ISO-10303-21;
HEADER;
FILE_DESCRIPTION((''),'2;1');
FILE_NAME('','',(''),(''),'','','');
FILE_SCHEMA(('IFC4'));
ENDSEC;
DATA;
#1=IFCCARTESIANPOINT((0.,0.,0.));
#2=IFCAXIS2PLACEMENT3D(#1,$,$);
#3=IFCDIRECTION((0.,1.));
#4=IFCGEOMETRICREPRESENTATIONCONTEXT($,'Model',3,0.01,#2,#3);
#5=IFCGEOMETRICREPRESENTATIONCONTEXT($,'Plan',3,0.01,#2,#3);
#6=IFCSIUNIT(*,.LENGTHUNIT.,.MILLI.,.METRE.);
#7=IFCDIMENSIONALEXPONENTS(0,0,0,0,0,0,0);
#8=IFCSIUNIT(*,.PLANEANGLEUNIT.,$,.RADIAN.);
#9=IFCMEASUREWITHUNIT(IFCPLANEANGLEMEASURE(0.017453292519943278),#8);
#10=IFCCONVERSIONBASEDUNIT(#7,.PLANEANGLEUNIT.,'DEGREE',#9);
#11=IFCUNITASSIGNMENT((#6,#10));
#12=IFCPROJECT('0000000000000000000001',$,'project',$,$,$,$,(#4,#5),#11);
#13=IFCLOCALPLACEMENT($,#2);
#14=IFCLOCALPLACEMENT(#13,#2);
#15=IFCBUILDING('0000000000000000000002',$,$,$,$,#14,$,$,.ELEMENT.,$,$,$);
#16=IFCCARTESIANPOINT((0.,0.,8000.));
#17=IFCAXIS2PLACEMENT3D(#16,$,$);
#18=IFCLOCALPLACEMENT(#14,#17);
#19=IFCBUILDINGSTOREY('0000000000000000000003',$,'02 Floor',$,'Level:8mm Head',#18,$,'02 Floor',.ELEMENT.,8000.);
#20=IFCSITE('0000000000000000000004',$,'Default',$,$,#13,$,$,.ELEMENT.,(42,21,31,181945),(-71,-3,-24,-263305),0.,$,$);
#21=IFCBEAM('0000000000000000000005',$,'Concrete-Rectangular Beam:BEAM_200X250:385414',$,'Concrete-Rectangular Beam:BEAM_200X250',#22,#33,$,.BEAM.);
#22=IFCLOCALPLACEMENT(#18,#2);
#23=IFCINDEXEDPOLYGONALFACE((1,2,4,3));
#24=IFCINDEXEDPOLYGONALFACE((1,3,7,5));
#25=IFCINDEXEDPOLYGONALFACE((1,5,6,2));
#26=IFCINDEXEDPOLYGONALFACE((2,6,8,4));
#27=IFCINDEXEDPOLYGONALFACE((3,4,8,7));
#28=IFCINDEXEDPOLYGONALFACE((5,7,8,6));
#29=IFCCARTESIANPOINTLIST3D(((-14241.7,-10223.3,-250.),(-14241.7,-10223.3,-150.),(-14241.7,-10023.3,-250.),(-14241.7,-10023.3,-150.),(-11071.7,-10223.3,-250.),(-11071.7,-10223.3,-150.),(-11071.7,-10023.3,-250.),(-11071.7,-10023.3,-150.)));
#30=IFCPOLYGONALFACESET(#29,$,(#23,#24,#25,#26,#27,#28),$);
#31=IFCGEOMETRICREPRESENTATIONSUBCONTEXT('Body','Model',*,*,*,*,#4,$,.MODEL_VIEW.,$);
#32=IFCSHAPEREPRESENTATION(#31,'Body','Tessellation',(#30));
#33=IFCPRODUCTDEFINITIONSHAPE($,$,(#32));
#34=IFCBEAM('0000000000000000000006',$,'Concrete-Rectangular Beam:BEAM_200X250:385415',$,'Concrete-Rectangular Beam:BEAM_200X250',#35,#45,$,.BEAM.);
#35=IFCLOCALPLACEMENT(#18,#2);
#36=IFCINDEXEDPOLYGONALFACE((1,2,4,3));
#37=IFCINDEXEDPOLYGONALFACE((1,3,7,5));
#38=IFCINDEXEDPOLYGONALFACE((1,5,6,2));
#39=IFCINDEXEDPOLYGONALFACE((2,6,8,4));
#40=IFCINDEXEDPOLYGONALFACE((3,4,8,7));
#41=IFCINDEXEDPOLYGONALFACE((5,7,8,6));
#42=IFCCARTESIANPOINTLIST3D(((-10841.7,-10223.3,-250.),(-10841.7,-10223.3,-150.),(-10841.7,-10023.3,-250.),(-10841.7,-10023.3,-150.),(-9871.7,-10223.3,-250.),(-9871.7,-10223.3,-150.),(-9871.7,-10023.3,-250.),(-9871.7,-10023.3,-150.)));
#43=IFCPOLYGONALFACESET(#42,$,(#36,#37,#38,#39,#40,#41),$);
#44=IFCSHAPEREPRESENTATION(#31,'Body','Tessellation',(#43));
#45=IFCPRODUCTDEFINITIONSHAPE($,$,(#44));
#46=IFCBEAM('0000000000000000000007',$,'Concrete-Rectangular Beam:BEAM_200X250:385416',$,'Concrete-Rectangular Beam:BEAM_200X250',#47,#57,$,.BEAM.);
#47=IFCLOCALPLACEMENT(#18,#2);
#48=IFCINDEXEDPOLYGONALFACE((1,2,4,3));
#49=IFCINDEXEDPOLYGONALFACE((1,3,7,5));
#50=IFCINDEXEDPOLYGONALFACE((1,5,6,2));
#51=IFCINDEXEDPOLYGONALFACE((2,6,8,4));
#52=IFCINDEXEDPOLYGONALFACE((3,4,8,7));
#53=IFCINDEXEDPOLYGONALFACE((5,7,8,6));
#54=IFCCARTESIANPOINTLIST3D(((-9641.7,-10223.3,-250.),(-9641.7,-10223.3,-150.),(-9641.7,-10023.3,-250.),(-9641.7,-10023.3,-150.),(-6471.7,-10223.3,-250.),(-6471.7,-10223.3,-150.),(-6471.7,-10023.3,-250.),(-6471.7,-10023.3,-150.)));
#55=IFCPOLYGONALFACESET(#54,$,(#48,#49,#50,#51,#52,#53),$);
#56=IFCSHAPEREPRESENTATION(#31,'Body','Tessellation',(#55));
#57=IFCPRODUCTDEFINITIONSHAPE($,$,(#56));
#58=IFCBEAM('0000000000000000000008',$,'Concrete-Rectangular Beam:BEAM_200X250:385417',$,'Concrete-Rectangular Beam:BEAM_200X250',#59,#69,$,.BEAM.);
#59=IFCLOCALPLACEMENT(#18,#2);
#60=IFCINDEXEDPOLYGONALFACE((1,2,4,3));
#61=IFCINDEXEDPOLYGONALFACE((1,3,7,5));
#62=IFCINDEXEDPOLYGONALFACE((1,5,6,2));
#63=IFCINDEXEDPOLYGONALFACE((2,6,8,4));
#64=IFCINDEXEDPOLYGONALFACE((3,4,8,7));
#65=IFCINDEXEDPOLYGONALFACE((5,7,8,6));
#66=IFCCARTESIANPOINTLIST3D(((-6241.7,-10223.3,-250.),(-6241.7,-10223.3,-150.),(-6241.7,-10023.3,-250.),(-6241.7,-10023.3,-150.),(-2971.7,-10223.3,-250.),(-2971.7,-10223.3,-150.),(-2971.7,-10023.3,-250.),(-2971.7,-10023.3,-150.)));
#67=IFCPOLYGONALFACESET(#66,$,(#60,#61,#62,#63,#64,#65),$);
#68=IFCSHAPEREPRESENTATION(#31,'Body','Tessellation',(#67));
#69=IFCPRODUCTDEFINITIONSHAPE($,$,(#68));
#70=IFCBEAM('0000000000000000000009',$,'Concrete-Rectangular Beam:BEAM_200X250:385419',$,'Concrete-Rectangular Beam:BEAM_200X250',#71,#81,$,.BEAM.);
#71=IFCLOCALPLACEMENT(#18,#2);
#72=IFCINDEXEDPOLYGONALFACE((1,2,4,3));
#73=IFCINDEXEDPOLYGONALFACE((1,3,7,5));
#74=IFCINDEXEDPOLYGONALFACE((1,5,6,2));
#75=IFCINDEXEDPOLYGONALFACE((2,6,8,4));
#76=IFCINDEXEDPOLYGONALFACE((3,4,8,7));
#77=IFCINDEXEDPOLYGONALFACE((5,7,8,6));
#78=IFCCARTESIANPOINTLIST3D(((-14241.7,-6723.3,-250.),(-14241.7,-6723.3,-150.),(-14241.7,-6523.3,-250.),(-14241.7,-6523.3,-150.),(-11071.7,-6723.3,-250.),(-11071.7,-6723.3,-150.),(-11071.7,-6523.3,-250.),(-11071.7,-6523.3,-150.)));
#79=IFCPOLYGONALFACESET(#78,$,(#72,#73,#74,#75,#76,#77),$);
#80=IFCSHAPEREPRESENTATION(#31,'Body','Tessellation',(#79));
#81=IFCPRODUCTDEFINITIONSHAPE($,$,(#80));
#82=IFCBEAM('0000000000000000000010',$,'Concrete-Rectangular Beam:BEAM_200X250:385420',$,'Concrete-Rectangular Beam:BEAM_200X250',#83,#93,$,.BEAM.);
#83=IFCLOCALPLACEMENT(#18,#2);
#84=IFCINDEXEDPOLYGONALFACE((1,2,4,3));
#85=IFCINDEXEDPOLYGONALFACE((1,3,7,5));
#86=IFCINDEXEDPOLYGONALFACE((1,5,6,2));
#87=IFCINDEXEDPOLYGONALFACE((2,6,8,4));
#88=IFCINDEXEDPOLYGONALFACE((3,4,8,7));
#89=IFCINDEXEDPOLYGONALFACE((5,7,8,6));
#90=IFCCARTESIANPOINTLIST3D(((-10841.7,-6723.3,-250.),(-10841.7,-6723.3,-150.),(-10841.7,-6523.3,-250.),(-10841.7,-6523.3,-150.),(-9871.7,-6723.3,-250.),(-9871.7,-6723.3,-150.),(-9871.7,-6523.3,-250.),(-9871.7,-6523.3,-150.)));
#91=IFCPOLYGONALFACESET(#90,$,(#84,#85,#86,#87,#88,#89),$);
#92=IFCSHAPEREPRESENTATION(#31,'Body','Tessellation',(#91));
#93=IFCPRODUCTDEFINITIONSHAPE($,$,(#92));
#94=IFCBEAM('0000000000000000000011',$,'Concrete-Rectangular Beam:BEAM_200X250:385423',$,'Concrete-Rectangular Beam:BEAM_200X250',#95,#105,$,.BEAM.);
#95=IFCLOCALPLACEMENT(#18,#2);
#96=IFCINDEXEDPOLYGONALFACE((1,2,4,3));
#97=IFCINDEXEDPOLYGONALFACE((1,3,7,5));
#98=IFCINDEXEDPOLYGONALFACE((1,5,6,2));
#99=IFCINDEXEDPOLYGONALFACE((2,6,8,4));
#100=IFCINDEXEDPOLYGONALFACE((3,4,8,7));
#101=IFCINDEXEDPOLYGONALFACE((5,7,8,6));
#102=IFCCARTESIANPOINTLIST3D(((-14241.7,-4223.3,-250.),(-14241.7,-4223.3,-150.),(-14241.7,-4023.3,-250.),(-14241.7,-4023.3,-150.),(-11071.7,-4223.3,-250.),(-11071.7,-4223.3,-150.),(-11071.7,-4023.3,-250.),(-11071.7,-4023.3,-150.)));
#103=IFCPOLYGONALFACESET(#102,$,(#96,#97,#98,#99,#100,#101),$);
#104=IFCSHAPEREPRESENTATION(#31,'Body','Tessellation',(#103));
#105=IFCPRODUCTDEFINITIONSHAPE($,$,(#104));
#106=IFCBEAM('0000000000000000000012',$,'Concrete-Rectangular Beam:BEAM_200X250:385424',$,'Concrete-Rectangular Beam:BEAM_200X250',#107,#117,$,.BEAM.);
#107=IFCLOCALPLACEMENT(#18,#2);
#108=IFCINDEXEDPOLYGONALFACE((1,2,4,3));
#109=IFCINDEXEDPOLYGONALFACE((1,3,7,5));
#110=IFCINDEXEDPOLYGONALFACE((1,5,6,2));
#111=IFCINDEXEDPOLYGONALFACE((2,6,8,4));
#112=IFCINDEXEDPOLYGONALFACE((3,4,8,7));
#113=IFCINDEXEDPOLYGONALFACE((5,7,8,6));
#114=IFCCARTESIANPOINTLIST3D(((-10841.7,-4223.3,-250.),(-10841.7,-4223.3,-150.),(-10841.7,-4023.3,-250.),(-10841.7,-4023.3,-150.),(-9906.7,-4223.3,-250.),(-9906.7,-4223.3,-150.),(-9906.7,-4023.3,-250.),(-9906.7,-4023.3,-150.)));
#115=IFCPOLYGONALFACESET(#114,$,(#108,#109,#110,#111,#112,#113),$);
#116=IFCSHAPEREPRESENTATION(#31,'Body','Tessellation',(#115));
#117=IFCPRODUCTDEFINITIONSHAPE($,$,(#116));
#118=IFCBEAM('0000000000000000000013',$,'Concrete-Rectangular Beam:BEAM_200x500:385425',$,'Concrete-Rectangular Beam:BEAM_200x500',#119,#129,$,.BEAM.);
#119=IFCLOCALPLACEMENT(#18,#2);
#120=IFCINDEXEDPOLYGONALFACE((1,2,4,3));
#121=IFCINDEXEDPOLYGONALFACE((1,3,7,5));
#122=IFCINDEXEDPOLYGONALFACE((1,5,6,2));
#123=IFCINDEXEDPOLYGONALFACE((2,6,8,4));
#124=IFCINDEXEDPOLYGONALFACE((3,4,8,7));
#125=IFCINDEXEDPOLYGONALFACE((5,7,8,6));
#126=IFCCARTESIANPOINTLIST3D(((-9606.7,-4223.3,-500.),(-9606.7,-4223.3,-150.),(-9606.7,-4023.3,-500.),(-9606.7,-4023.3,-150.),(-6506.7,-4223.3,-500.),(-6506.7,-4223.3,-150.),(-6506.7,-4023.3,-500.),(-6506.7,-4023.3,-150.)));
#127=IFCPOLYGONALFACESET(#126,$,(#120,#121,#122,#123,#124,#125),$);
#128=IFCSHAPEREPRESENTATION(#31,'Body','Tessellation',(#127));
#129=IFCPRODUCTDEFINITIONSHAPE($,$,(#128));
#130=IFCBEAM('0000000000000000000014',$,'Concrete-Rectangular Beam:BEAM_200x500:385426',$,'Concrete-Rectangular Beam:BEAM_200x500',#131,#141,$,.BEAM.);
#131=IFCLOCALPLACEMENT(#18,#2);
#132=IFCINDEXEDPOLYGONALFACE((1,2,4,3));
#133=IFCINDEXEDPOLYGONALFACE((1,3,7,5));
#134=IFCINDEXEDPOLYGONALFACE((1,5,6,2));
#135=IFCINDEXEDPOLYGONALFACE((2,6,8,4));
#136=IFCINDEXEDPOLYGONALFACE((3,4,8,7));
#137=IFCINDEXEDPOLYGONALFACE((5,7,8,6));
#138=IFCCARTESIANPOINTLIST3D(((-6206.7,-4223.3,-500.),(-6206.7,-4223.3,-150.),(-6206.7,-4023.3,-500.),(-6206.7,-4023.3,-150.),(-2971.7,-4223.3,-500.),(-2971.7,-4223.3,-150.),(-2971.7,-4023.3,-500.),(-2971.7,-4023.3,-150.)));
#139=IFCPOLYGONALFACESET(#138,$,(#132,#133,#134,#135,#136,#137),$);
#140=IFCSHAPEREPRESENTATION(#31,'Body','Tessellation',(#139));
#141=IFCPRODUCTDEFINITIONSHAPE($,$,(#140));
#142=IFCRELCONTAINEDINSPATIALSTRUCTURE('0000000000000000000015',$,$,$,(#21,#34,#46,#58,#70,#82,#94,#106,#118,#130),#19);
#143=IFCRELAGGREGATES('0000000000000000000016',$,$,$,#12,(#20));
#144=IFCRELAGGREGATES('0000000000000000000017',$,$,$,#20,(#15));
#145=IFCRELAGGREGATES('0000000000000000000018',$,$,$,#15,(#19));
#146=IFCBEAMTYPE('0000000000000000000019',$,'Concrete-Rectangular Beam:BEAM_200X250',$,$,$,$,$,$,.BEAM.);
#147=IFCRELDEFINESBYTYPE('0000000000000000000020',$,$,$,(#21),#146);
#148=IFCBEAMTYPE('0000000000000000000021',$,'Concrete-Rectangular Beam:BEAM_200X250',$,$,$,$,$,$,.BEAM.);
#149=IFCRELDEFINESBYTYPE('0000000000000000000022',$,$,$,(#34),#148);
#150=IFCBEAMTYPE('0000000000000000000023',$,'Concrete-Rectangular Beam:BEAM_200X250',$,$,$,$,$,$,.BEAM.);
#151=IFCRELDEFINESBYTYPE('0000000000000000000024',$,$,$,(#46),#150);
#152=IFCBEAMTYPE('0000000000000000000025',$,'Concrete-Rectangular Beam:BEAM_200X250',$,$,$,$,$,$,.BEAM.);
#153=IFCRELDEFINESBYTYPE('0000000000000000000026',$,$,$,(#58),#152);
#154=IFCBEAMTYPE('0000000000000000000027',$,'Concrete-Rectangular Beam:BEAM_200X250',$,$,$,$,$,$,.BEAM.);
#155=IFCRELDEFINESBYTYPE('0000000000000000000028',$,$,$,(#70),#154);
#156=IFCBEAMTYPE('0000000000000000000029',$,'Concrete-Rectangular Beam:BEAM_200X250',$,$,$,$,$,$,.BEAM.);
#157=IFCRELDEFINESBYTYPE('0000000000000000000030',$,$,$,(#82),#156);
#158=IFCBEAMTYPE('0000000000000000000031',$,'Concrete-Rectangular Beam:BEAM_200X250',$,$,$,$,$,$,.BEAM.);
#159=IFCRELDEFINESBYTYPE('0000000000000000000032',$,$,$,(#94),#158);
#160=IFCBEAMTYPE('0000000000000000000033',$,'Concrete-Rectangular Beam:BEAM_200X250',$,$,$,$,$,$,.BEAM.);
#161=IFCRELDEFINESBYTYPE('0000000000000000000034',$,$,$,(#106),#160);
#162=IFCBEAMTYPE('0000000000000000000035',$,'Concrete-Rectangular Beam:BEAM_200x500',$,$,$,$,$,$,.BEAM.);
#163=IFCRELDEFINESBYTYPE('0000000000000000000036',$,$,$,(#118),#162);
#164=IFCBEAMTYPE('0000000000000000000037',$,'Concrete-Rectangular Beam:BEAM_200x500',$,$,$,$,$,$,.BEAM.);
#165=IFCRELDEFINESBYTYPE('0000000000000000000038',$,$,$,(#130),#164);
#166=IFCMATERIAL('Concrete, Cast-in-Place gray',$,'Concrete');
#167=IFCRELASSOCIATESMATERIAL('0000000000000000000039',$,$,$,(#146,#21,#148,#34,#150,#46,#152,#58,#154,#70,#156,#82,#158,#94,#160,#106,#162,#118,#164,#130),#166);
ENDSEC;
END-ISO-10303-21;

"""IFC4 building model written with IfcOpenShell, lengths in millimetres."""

from ifc_helpers import new_model, entity, si_unit, converted_unit, direction, frame, origin, place, context, subcontext, project, spatial, indexed_curve, outline, extrude, source, transform, mapped, material, type_object, type_shapes, element, save


model = new_model("IFC4")

# Units and contexts
model_context = context("Model", 3, precision=0.01, world=origin(), true_north=direction((0.0, 1.0)))
plan_context = context("Plan", 3, precision=0.01, world=origin(), true_north=direction((0.0, 1.0)))
body_context = subcontext(model_context, "Body", "Model", "MODEL_VIEW")
ifc_project = project(units=[si_unit("LENGTHUNIT", "METRE", prefix="MILLI"), converted_unit("PLANEANGLEUNIT", "DEGREE", entity("IfcPlaneAngleMeasure", 0.017453292519943278), si_unit("PLANEANGLEUNIT", "RADIAN"), dimensions=[0, 0, 0, 0, 0, 0, 0])], contexts=[model_context, plan_context])

# Site, building, storey
site_placement = place(None, origin())
site = spatial("IfcSite", under=ifc_project, at=site_placement, Name="Default", CompositionType="ELEMENT", RefLatitude=(42, 21, 31, 181945), RefLongitude=(-71, -3, -24, -263305), RefElevation=0.0)
building_placement = place(site_placement, origin())
building = spatial("IfcBuilding", under=site, at=building_placement, CompositionType="ELEMENT")
storey_placement = place(building_placement, frame((0.0, 0.0, 8000.0)))
storey = spatial("IfcBuildingStorey", under=building, at=storey_placement, Name="02 Floor", ObjectType="Level:8mm Head", LongName="02 Floor", CompositionType="ELEMENT", Elevation=8000.0)

# Beams
ifc_material_1 = material(Name="Concrete, Cast-in-Place gray", Category="Concrete")
beam_type_1 = type_object("IfcBeamType", Name="Concrete-Rectangular Beam:BEAM_200X250", PredefinedType="BEAM", material=ifc_material_1)
shared_shape_1 = source(origin(), body_context, "Body", "SweptSolid", [
    extrude(outline(indexed_curve([(-50.0, -100.0), (50.0, -100.0), (50.0, 100.0), (-50.0, 100.0), (-50.0, -100.0)], self_intersect=False)), frame((-14241.7, -10123.3, 7800.0), z_axis=(1.0, 0.0, 0.0), x_axis=(0.0, 0.0, -1.0)), (0.0, 0.0, 1.0), 3170.0),
])
type_shapes(beam_type_1, [shared_shape_1])
beam_1_placement = place(storey_placement, frame((0.0, 0.0, -8000.0)))
element("IfcBeam", 1, at=beam_1_placement, inside=storey, type_object=beam_type_1, material=ifc_material_1, Name="Concrete-Rectangular Beam:BEAM_200X250:385414", ObjectType="Concrete-Rectangular Beam:BEAM_200X250", PredefinedType="BEAM", context=body_context, shape_type="MappedRepresentation", body=[
    mapped(shared_shape_1, transform((0.0, 0.0, 0.0), scale=1.0)),
])
beam_type_2 = type_object("IfcBeamType", Name="Concrete-Rectangular Beam:BEAM_200X250", PredefinedType="BEAM", material=ifc_material_1)
shared_shape_2 = source(origin(), body_context, "Body", "SweptSolid", [
    extrude(outline(indexed_curve([(-50.0, -100.0), (50.0, -100.0), (50.0, 100.0), (-50.0, 100.0), (-50.0, -100.0)], self_intersect=False)), frame((-10841.7, -10123.3, 7800.0), z_axis=(1.0, 0.0, 0.0), x_axis=(0.0, 0.0, -1.0)), (0.0, 0.0, 1.0), 970.0),
])
type_shapes(beam_type_2, [shared_shape_2])
beam_2_placement = place(storey_placement, frame((0.0, 0.0, -8000.0)))
element("IfcBeam", 2, at=beam_2_placement, inside=storey, type_object=beam_type_2, material=ifc_material_1, Name="Concrete-Rectangular Beam:BEAM_200X250:385415", ObjectType="Concrete-Rectangular Beam:BEAM_200X250", PredefinedType="BEAM", context=body_context, shape_type="MappedRepresentation", body=[
    mapped(shared_shape_2, transform((0.0, 0.0, 0.0), scale=1.0)),
])
beam_type_3 = type_object("IfcBeamType", Name="Concrete-Rectangular Beam:BEAM_200X250", PredefinedType="BEAM", material=ifc_material_1)
shared_shape_3 = source(origin(), body_context, "Body", "SweptSolid", [
    extrude(outline(indexed_curve([(-50.0, -100.0), (50.0, -100.0), (50.0, 100.0), (-50.0, 100.0), (-50.0, -100.0)], self_intersect=False)), frame((-9641.7, -10123.3, 7800.0), z_axis=(1.0, 0.0, 0.0), x_axis=(0.0, 0.0, -1.0)), (0.0, 0.0, 1.0), 3170.0),
])
type_shapes(beam_type_3, [shared_shape_3])
beam_3_placement = place(storey_placement, frame((0.0, 0.0, -8000.0)))
element("IfcBeam", 3, at=beam_3_placement, inside=storey, type_object=beam_type_3, material=ifc_material_1, Name="Concrete-Rectangular Beam:BEAM_200X250:385416", ObjectType="Concrete-Rectangular Beam:BEAM_200X250", PredefinedType="BEAM", context=body_context, shape_type="MappedRepresentation", body=[
    mapped(shared_shape_3, transform((0.0, 0.0, 0.0), scale=1.0)),
])
beam_type_4 = type_object("IfcBeamType", Name="Concrete-Rectangular Beam:BEAM_200X250", PredefinedType="BEAM", material=ifc_material_1)
shared_shape_4 = source(origin(), body_context, "Body", "SweptSolid", [
    extrude(outline(indexed_curve([(-50.0, -100.0), (50.0, -100.0), (50.0, 100.0), (-50.0, 100.0), (-50.0, -100.0)], self_intersect=False)), frame((-6241.7, -10123.3, 7800.0), z_axis=(1.0, 0.0, 0.0), x_axis=(0.0, 0.0, -1.0)), (0.0, 0.0, 1.0), 3270.0),
])
type_shapes(beam_type_4, [shared_shape_4])
beam_4_placement = place(storey_placement, frame((0.0, 0.0, -8000.0)))
element("IfcBeam", 4, at=beam_4_placement, inside=storey, type_object=beam_type_4, material=ifc_material_1, Name="Concrete-Rectangular Beam:BEAM_200X250:385417", ObjectType="Concrete-Rectangular Beam:BEAM_200X250", PredefinedType="BEAM", context=body_context, shape_type="MappedRepresentation", body=[
    mapped(shared_shape_4, transform((0.0, 0.0, 0.0), scale=1.0)),
])
beam_type_5 = type_object("IfcBeamType", Name="Concrete-Rectangular Beam:BEAM_200X250", PredefinedType="BEAM", material=ifc_material_1)
shared_shape_5 = source(origin(), body_context, "Body", "SweptSolid", [
    extrude(outline(indexed_curve([(-50.0, -100.0), (50.0, -100.0), (50.0, 100.0), (-50.0, 100.0), (-50.0, -100.0)], self_intersect=False)), frame((-14241.7, -6623.3, 7800.0), z_axis=(1.0, 0.0, 0.0), x_axis=(0.0, 0.0, -1.0)), (0.0, 0.0, 1.0), 3170.0),
])
type_shapes(beam_type_5, [shared_shape_5])
beam_5_placement = place(storey_placement, frame((0.0, 0.0, -8000.0)))
element("IfcBeam", 5, at=beam_5_placement, inside=storey, type_object=beam_type_5, material=ifc_material_1, Name="Concrete-Rectangular Beam:BEAM_200X250:385419", ObjectType="Concrete-Rectangular Beam:BEAM_200X250", PredefinedType="BEAM", context=body_context, shape_type="MappedRepresentation", body=[
    mapped(shared_shape_5, transform((0.0, 0.0, 0.0), scale=1.0)),
])
beam_type_6 = type_object("IfcBeamType", Name="Concrete-Rectangular Beam:BEAM_200X250", PredefinedType="BEAM", material=ifc_material_1)
shared_shape_6 = source(origin(), body_context, "Body", "SweptSolid", [
    extrude(outline(indexed_curve([(-50.0, -100.0), (50.0, -100.0), (50.0, 100.0), (-50.0, 100.0), (-50.0, -100.0)], self_intersect=False)), frame((-10841.7, -6623.3, 7800.0), z_axis=(1.0, 0.0, 0.0), x_axis=(0.0, 0.0, -1.0)), (0.0, 0.0, 1.0), 970.0),
])
type_shapes(beam_type_6, [shared_shape_6])
beam_6_placement = place(storey_placement, frame((0.0, 0.0, -8000.0)))
element("IfcBeam", 6, at=beam_6_placement, inside=storey, type_object=beam_type_6, material=ifc_material_1, Name="Concrete-Rectangular Beam:BEAM_200X250:385420", ObjectType="Concrete-Rectangular Beam:BEAM_200X250", PredefinedType="BEAM", context=body_context, shape_type="MappedRepresentation", body=[
    mapped(shared_shape_6, transform((0.0, 0.0, 0.0), scale=1.0)),
])
beam_type_7 = type_object("IfcBeamType", Name="Concrete-Rectangular Beam:BEAM_200X250", PredefinedType="BEAM", material=ifc_material_1)
shared_shape_7 = source(origin(), body_context, "Body", "SweptSolid", [
    extrude(outline(indexed_curve([(-50.0, -100.0), (50.0, -100.0), (50.0, 100.0), (-50.0, 100.0), (-50.0, -100.0)], self_intersect=False)), frame((-14241.7, -4123.3, 7800.0), z_axis=(1.0, 0.0, 0.0), x_axis=(0.0, 0.0, -1.0)), (0.0, 0.0, 1.0), 3170.0),
])
type_shapes(beam_type_7, [shared_shape_7])
beam_7_placement = place(storey_placement, frame((0.0, 0.0, -8000.0)))
element("IfcBeam", 7, at=beam_7_placement, inside=storey, type_object=beam_type_7, material=ifc_material_1, Name="Concrete-Rectangular Beam:BEAM_200X250:385423", ObjectType="Concrete-Rectangular Beam:BEAM_200X250", PredefinedType="BEAM", context=body_context, shape_type="MappedRepresentation", body=[
    mapped(shared_shape_7, transform((0.0, 0.0, 0.0), scale=1.0)),
])
beam_type_8 = type_object("IfcBeamType", Name="Concrete-Rectangular Beam:BEAM_200X250", PredefinedType="BEAM", material=ifc_material_1)
shared_shape_8 = source(origin(), body_context, "Body", "SweptSolid", [
    extrude(outline(indexed_curve([(-50.0, -100.0), (50.0, -100.0), (50.0, 100.0), (-50.0, 100.0), (-50.0, -100.0)], self_intersect=False)), frame((-10841.7, -4123.3, 7800.0), z_axis=(1.0, 0.0, 0.0), x_axis=(0.0, 0.0, -1.0)), (0.0, 0.0, 1.0), 935.0),
])
type_shapes(beam_type_8, [shared_shape_8])
beam_8_placement = place(storey_placement, frame((0.0, 0.0, -8000.0)))
element("IfcBeam", 8, at=beam_8_placement, inside=storey, type_object=beam_type_8, material=ifc_material_1, Name="Concrete-Rectangular Beam:BEAM_200X250:385424", ObjectType="Concrete-Rectangular Beam:BEAM_200X250", PredefinedType="BEAM", context=body_context, shape_type="MappedRepresentation", body=[
    mapped(shared_shape_8, transform((0.0, 0.0, 0.0), scale=1.0)),
])
beam_type_9 = type_object("IfcBeamType", Name="Concrete-Rectangular Beam:BEAM_200x500", PredefinedType="BEAM", material=ifc_material_1)
shared_shape_9 = source(origin(), body_context, "Body", "SweptSolid", [
    extrude(outline(indexed_curve([(-175.0, -100.0), (175.0, -100.0), (175.0, 100.0), (-175.0, 100.0), (-175.0, -100.0)], self_intersect=False)), frame((-9606.7, -4123.3, 7675.0), z_axis=(1.0, 0.0, 0.0), x_axis=(0.0, 0.0, -1.0)), (0.0, 0.0, 1.0), 3100.0),
])
type_shapes(beam_type_9, [shared_shape_9])
beam_9_placement = place(storey_placement, frame((0.0, 0.0, -8000.0)))
element("IfcBeam", 9, at=beam_9_placement, inside=storey, type_object=beam_type_9, material=ifc_material_1, Name="Concrete-Rectangular Beam:BEAM_200x500:385425", ObjectType="Concrete-Rectangular Beam:BEAM_200x500", PredefinedType="BEAM", context=body_context, shape_type="MappedRepresentation", body=[
    mapped(shared_shape_9, transform((0.0, 0.0, 0.0), scale=1.0)),
])
beam_type_10 = type_object("IfcBeamType", Name="Concrete-Rectangular Beam:BEAM_200x500", PredefinedType="BEAM", material=ifc_material_1)
shared_shape_10 = source(origin(), body_context, "Body", "SweptSolid", [
    extrude(outline(indexed_curve([(-175.0, -100.0), (175.0, -100.0), (175.0, 100.0), (-175.0, 100.0), (-175.0, -100.0)], self_intersect=False)), frame((-6206.7, -4123.3, 7675.0), z_axis=(1.0, 0.0, 0.0), x_axis=(0.0, 0.0, -1.0)), (0.0, 0.0, 1.0), 3235.0),
])
type_shapes(beam_type_10, [shared_shape_10])
beam_10_placement = place(storey_placement, frame((0.0, 0.0, -8000.0)))
element("IfcBeam", 10, at=beam_10_placement, inside=storey, type_object=beam_type_10, material=ifc_material_1, Name="Concrete-Rectangular Beam:BEAM_200x500:385426", ObjectType="Concrete-Rectangular Beam:BEAM_200x500", PredefinedType="BEAM", context=body_context, shape_type="MappedRepresentation", body=[
    mapped(shared_shape_10, transform((0.0, 0.0, 0.0), scale=1.0)),
])

save(model, "model.ifc")
